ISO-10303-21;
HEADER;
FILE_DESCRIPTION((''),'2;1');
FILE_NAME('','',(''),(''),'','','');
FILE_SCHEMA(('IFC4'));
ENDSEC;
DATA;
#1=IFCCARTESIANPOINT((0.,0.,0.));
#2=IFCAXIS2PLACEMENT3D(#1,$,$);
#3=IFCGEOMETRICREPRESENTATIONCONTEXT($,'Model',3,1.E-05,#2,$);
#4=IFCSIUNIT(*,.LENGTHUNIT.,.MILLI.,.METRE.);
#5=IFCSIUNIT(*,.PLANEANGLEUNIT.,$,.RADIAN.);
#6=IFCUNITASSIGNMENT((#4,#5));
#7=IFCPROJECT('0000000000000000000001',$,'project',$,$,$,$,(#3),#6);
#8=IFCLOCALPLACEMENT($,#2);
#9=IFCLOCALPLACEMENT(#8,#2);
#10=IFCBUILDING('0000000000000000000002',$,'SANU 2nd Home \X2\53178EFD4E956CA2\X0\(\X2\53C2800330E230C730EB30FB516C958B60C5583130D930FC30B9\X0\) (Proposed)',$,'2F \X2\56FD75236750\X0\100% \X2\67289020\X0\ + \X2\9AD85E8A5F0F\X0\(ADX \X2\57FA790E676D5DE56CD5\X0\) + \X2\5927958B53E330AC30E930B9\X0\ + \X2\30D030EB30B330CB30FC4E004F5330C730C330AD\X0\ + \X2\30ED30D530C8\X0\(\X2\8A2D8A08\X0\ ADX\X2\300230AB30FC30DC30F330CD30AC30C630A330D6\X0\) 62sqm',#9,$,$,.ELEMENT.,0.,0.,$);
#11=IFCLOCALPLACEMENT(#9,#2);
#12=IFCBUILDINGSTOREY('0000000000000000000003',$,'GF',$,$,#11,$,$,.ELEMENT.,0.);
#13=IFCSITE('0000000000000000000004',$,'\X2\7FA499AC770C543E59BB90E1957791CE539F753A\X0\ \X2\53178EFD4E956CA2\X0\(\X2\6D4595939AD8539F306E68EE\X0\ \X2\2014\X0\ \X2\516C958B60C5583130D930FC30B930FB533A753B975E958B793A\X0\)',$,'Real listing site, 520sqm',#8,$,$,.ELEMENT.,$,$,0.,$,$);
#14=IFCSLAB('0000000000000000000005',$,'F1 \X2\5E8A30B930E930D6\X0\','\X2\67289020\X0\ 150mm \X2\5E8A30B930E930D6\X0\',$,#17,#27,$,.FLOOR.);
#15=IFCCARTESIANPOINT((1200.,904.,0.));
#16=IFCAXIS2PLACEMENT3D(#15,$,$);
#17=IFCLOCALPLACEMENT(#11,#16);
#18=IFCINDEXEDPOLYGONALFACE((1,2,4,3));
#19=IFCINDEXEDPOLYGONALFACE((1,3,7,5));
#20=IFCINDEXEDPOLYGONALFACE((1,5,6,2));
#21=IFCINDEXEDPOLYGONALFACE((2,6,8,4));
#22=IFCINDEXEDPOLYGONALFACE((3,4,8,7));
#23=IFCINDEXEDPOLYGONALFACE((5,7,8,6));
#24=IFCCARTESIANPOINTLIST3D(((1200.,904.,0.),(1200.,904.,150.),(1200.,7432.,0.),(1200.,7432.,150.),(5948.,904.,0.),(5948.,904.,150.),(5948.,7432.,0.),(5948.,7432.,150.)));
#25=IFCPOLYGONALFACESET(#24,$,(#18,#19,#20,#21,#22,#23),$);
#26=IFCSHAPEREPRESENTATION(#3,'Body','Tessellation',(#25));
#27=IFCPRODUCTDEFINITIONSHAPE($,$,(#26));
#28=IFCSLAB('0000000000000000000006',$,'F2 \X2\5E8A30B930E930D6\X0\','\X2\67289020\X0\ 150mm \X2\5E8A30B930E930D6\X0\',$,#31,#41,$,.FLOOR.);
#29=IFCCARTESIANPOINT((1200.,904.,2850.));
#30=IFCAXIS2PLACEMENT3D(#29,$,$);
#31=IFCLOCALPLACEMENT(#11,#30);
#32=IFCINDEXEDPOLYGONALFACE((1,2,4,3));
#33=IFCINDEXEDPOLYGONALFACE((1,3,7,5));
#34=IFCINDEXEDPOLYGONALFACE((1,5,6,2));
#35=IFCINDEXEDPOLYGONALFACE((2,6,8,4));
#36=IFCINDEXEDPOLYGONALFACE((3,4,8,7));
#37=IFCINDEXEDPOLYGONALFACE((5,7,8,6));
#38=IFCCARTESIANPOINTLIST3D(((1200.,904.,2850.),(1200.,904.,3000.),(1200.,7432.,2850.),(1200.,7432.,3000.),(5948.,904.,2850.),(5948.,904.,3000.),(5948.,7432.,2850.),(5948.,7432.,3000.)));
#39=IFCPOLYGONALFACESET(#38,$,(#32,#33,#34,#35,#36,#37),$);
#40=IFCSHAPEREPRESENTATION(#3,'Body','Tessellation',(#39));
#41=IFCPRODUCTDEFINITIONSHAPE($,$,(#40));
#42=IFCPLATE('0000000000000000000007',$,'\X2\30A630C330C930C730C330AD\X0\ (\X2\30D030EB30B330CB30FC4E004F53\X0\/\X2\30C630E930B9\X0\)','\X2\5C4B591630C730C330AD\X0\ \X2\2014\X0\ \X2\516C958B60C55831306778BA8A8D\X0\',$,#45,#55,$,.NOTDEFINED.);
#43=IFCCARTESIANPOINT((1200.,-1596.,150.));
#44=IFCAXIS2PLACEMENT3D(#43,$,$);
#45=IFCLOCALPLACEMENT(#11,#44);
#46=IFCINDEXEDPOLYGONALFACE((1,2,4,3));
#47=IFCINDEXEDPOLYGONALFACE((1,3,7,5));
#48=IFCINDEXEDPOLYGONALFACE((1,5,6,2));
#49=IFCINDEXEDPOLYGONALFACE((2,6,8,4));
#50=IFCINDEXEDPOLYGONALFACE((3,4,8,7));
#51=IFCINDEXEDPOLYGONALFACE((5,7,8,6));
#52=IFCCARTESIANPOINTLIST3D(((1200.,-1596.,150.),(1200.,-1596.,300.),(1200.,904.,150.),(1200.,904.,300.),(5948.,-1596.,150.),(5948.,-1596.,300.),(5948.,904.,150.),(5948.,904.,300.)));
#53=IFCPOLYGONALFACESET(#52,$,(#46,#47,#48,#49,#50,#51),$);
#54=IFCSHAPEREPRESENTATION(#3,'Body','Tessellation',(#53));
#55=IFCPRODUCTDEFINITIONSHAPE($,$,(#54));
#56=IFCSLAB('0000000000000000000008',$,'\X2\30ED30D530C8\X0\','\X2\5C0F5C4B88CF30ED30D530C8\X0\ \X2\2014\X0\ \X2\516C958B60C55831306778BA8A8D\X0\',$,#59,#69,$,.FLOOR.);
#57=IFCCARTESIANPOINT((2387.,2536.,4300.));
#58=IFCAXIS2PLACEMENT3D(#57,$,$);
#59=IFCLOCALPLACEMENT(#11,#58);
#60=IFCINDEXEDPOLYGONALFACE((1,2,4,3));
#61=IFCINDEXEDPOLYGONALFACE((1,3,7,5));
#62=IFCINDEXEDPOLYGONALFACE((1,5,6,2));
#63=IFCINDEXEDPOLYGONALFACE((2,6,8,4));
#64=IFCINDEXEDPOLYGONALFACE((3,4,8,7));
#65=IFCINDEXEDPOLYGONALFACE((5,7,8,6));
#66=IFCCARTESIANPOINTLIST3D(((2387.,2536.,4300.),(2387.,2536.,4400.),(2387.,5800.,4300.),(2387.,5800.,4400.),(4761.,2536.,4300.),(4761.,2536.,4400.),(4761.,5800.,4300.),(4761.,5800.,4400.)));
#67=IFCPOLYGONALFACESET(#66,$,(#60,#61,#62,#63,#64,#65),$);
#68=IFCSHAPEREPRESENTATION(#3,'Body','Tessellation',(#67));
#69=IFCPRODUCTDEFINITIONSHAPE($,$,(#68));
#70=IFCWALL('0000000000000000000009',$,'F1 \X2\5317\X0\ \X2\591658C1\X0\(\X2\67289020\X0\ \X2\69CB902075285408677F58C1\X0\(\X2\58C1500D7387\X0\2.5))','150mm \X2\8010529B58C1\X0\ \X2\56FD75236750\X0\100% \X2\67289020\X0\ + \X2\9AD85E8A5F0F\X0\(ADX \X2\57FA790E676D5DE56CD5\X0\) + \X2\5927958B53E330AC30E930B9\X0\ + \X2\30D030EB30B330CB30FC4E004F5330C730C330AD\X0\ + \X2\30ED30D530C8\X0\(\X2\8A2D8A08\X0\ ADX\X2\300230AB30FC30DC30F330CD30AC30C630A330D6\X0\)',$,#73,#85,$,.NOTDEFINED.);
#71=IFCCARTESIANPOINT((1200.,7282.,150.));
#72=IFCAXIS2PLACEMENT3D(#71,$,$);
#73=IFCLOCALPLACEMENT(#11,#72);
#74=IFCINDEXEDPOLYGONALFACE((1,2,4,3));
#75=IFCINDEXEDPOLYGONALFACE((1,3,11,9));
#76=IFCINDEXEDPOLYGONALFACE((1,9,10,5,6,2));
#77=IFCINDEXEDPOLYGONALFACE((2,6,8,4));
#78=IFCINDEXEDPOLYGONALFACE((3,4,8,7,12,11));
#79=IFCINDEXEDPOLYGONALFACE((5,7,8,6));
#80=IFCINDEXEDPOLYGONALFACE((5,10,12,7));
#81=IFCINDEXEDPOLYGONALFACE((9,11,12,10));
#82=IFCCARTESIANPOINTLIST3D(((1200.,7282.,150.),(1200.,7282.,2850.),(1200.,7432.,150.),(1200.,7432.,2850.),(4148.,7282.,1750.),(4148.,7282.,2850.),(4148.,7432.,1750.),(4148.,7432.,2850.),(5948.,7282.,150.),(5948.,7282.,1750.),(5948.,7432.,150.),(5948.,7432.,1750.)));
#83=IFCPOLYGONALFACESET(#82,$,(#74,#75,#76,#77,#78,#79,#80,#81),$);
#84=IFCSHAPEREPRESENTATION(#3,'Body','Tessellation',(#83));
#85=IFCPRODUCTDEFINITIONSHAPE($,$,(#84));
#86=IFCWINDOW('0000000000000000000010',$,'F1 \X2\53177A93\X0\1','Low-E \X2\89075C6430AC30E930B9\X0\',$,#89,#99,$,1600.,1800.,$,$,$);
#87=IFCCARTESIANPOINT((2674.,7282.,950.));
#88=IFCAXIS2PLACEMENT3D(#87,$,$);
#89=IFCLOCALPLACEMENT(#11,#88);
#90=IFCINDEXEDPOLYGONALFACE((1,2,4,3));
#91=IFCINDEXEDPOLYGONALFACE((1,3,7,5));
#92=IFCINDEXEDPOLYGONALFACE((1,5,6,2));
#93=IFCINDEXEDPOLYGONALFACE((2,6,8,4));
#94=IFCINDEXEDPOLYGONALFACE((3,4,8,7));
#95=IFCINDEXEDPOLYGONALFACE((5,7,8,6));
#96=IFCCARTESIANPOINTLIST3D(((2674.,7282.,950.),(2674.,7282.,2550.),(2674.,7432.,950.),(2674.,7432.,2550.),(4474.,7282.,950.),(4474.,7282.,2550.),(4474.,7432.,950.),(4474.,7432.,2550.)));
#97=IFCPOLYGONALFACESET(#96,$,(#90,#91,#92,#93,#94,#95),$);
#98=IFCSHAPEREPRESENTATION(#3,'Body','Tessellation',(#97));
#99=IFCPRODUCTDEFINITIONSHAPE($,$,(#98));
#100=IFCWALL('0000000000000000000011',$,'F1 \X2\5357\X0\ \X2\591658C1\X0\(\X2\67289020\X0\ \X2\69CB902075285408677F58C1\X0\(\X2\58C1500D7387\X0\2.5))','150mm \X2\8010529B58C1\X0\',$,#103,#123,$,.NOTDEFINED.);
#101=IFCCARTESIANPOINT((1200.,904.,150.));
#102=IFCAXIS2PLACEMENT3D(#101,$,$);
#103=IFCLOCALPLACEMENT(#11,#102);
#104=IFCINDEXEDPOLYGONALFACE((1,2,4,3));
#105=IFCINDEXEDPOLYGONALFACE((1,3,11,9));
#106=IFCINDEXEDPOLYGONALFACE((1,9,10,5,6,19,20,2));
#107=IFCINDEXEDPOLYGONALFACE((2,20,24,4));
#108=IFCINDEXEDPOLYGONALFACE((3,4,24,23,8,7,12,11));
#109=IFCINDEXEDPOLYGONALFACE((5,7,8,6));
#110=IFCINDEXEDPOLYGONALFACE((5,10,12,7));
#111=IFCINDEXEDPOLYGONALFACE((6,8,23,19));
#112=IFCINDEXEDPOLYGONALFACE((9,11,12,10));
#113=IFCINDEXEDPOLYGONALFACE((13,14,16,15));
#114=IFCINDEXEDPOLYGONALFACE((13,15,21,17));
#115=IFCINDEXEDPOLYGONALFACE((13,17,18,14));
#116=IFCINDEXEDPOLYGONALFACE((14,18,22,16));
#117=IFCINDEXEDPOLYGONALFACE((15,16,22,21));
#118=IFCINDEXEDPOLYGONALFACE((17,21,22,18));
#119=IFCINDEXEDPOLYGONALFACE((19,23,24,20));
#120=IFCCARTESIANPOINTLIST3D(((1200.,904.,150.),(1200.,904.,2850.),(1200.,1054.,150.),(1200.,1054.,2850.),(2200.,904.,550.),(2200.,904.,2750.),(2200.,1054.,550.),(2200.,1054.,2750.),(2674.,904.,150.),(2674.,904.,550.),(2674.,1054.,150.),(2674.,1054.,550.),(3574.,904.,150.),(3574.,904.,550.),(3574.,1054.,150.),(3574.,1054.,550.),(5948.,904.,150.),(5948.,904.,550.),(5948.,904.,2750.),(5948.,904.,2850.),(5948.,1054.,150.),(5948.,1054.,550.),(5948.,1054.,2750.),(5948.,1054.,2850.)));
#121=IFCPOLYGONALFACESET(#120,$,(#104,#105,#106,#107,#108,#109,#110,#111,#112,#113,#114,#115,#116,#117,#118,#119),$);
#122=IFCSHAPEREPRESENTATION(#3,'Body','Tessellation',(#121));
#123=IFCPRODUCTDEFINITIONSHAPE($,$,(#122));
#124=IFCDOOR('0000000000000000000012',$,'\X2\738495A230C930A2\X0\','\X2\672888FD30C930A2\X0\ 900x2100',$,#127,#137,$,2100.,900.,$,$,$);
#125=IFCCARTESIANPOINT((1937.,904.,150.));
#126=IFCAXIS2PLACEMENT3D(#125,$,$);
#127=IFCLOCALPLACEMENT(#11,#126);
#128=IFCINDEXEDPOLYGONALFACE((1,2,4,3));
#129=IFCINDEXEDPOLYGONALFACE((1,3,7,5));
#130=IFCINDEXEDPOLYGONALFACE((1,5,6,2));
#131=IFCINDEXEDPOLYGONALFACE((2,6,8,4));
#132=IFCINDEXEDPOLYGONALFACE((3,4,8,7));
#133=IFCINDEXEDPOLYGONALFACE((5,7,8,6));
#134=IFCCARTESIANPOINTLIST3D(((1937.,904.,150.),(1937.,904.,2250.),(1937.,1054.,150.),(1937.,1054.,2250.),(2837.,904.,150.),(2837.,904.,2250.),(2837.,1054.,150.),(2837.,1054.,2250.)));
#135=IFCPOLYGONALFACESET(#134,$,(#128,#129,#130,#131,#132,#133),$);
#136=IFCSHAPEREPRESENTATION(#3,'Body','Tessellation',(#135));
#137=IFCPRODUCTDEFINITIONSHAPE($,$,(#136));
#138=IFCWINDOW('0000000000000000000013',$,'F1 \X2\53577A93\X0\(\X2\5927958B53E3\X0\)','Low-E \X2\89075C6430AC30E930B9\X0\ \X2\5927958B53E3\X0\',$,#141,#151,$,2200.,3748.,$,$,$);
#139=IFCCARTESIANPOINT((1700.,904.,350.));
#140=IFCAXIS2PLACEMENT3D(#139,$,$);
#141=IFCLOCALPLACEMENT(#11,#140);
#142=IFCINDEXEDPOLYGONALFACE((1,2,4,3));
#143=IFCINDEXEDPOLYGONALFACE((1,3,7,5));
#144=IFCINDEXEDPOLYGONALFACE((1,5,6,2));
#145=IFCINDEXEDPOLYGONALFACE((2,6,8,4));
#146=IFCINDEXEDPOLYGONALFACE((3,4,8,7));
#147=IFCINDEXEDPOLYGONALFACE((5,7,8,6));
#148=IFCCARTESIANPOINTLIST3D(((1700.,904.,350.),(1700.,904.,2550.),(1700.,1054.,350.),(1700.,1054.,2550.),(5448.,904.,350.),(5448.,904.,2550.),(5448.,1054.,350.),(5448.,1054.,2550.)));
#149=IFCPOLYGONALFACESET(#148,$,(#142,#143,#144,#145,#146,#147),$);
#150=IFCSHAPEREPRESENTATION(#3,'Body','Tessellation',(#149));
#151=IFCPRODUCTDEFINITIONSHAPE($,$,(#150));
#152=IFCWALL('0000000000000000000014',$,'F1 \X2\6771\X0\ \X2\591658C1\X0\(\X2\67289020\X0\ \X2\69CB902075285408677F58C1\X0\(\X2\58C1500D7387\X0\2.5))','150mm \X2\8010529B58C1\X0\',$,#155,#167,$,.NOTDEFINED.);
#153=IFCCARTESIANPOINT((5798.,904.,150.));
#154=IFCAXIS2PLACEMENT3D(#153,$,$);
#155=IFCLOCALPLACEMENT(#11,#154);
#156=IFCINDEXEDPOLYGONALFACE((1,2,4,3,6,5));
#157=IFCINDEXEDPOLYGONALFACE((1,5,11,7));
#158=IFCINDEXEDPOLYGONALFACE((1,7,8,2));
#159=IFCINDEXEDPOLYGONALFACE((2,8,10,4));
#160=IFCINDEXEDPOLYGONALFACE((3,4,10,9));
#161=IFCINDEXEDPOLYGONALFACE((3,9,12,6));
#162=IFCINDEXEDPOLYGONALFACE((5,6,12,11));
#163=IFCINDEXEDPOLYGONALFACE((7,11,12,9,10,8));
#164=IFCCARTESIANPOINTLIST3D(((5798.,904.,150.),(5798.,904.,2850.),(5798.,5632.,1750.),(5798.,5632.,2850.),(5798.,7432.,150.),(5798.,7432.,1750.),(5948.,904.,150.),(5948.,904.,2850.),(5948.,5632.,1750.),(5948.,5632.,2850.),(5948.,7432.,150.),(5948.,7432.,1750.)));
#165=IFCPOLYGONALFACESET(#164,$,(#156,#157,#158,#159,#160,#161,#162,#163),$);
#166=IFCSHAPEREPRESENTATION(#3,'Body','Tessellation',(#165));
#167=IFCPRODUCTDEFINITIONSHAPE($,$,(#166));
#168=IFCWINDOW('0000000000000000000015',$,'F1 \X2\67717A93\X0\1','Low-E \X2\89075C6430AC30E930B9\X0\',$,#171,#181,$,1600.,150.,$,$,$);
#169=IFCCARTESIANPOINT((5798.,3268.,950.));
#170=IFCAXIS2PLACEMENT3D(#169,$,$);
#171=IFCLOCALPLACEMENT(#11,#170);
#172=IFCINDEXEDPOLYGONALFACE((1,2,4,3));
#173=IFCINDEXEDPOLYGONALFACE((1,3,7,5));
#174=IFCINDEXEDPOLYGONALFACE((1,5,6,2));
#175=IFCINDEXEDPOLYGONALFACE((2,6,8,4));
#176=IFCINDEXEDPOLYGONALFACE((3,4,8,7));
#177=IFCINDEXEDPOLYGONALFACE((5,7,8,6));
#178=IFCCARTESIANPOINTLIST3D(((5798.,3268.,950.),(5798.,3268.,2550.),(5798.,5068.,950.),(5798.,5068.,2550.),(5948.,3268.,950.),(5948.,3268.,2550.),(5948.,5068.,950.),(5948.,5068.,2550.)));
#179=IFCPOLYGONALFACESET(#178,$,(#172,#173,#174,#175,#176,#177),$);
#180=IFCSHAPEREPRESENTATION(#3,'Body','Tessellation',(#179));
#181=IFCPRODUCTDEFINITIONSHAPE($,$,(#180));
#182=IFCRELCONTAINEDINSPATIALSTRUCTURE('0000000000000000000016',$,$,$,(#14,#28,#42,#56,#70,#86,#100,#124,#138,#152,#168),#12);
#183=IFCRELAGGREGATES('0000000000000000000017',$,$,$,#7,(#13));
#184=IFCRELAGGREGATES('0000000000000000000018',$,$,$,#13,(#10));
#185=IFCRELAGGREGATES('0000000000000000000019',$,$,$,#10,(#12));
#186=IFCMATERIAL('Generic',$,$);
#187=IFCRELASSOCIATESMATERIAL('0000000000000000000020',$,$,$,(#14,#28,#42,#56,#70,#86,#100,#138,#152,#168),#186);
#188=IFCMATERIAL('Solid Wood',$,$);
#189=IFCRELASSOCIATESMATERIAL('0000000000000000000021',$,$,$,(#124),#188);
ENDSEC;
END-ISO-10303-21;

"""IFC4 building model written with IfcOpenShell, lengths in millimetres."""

from ifc_helpers import new_model, si_unit, frame, frame_2d, origin, place, context, project, spatial, rectangle, extrude, material, element, fill, save


model = new_model("IFC4")

# Units and contexts
model_context = context("Model", 3, precision=1e-05, world=origin())
ifc_project = project(units=[si_unit("LENGTHUNIT", "METRE", prefix="MILLI"), si_unit("PLANEANGLEUNIT", "RADIAN")], contexts=[model_context])

# Site, building, storey
site_placement = place(None, origin())
site = spatial("IfcSite", under=ifc_project, at=site_placement, Name="群馬県吾妻郡長野原町 北軽井沢(浅間高原の森 — 公開情報ベース・区画非開示)", ObjectType="Real listing site, 520sqm", CompositionType="ELEMENT", RefElevation=0.0)
building_placement = place(site_placement, origin())
building = spatial("IfcBuilding", under=site, at=building_placement, Name="SANU 2nd Home 北軽井沢(参考モデル・公開情報ベース) (Proposed)", ObjectType="2F 国産材100% 木造 + 高床式(ADX 基礎杭工法) + 大開口ガラス + バルコニー一体デッキ + ロフト(設計 ADX。カーボンネガティブ) 62sqm", CompositionType="ELEMENT", ElevationOfRefHeight=0.0, ElevationOfTerrain=0.0)
storey_placement = place(building_placement, origin())
storey = spatial("IfcBuildingStorey", under=building, at=storey_placement, Name="GF", CompositionType="ELEMENT", Elevation=0.0)

# Slabs
ifc_material_1 = material(Name="Generic")
slab_1_placement = place(storey_placement, frame((1200.0, 904.0, 0.0)))
element("IfcSlab", 1, at=slab_1_placement, inside=storey, material=ifc_material_1, Name="F1 床スラブ", Description="木造 150mm 床スラブ", PredefinedType="FLOOR", context=model_context, shape_type="SweptSolid", body=[
    extrude(rectangle(XDim=4748.0, YDim=6528.0, at=frame_2d((2374.0, 3264.0))), frame((1200.0, 904.0, 0.0)), (0.0, 0.0, 1.0), 150.0),
])
slab_2_placement = place(storey_placement, frame((1200.0, 904.0, 2850.0)))
element("IfcSlab", 2, at=slab_2_placement, inside=storey, material=ifc_material_1, Name="F2 床スラブ", Description="木造 150mm 床スラブ", PredefinedType="FLOOR", context=model_context, shape_type="SweptSolid", body=[
    extrude(rectangle(XDim=4748.0, YDim=6528.0, at=frame_2d((2374.0, 3264.0))), frame((1200.0, 904.0, 2850.0)), (0.0, 0.0, 1.0), 150.0),
])

# Plate
plate_placement = place(storey_placement, frame((1200.0, -1596.0, 150.0)))
element("IfcPlate", 3, at=plate_placement, inside=storey, material=ifc_material_1, Name="ウッドデッキ (バルコニー一体/テラス)", Description="屋外デッキ — 公開情報で確認", PredefinedType="NOTDEFINED", context=model_context, shape_type="SweptSolid", body=[
    extrude(rectangle(XDim=4748.0, YDim=2500.0, at=frame_2d((2374.0, 1250.0))), frame((1200.0, -1596.0, 150.0)), (0.0, 0.0, 1.0), 150.0),
])

# Slab
slab_3_placement = place(storey_placement, frame((2387.0, 2536.0, 4300.0)))
element("IfcSlab", 4, at=slab_3_placement, inside=storey, material=ifc_material_1, Name="ロフト", Description="小屋裏ロフト — 公開情報で確認", PredefinedType="FLOOR", context=model_context, shape_type="SweptSolid", body=[
    extrude(rectangle(XDim=2374.0, YDim=3264.0, at=frame_2d((1187.0, 1632.0))), frame((2387.0, 2536.0, 4300.0)), (0.0, 0.0, 1.0), 100.0),
])

# Wall, opening, window
wall_1_placement = place(storey_placement, frame((1200.0, 7282.0, 150.0)))
wall_1 = element("IfcWall", 5, at=wall_1_placement, inside=storey, material=ifc_material_1, Name="F1 北 外壁(木造 構造用合板壁(壁倍率2.5))", Description="150mm 耐力壁 国産材100% 木造 + 高床式(ADX 基礎杭工法) + 大開口ガラス + バルコニー一体デッキ + ロフト(設計 ADX。カーボンネガティブ)", PredefinedType="NOTDEFINED", context=model_context, shape_type="SweptSolid", body=[
    extrude(rectangle(XDim=4748.0, YDim=150.0, at=frame_2d((2374.0, 75.0))), frame((1200.0, 7282.0, 150.0)), (0.0, 0.0, 1.0), 2700.0),
])
opening_1_placement = place(storey_placement, frame((2674.0, 7282.0, 950.0)))
opening_1 = element("IfcOpeningElement", 6, at=opening_1_placement, cuts=wall_1, PredefinedType="NOTDEFINED", context=model_context, shape_type="SweptSolid", body=[
    extrude(rectangle(XDim=1800.0, YDim=150.0, at=frame_2d((900.0, 75.0))), frame((2674.0, 7282.0, 950.0)), (0.0, 0.0, 1.0), 1600.0),
])
window_1_placement = place(storey_placement, frame((2674.0, 7282.0, 950.0)))
window_1 = element("IfcWindow", 7, at=window_1_placement, inside=storey, material=ifc_material_1, Name="F1 北窓1", Description="Low-E 複層ガラス", OverallHeight=1600.0, OverallWidth=1800.0, context=model_context, shape_type="SweptSolid", body=[
    extrude(rectangle(XDim=1800.0, YDim=150.0, at=frame_2d((900.0, 75.0))), frame((2674.0, 7282.0, 950.0)), (0.0, 0.0, 1.0), 1600.0),
])
fill(opening_1, window_1)

# Wall, openings, door, window
wall_2_placement = place(storey_placement, frame((1200.0, 904.0, 150.0)))
wall_2 = element("IfcWall", 8, at=wall_2_placement, inside=storey, material=ifc_material_1, Name="F1 南 外壁(木造 構造用合板壁(壁倍率2.5))", Description="150mm 耐力壁", PredefinedType="NOTDEFINED", context=model_context, shape_type="SweptSolid", body=[
    extrude(rectangle(XDim=4748.0, YDim=150.0, at=frame_2d((2374.0, 75.0))), frame((1200.0, 904.0, 150.0)), (0.0, 0.0, 1.0), 2700.0),
])
opening_2_placement = place(storey_placement, frame((1937.0, 904.0, 150.0)))
opening_2 = element("IfcOpeningElement", 9, at=opening_2_placement, cuts=wall_2, PredefinedType="NOTDEFINED", context=model_context, shape_type="SweptSolid", body=[
    extrude(rectangle(XDim=900.0, YDim=150.0, at=frame_2d((450.0, 75.0))), frame((1937.0, 904.0, 150.0)), (0.0, 0.0, 1.0), 2100.0),
])
opening_3_placement = place(storey_placement, frame((1700.0, 904.0, 350.0)))
opening_3 = element("IfcOpeningElement", 10, at=opening_3_placement, cuts=wall_2, PredefinedType="NOTDEFINED", context=model_context, shape_type="SweptSolid", body=[
    extrude(rectangle(XDim=3748.0, YDim=150.0, at=frame_2d((1874.0, 75.0))), frame((1700.0, 904.0, 350.0)), (0.0, 0.0, 1.0), 2200.0),
])
ifc_material_2 = material(Name="Solid Wood")
door_placement = place(storey_placement, frame((1937.0, 904.0, 150.0)))
door = element("IfcDoor", 11, at=door_placement, inside=storey, material=ifc_material_2, Name="玄関ドア", Description="木製ドア 900x2100", OverallHeight=2100.0, OverallWidth=900.0, context=model_context, shape_type="SweptSolid", body=[
    extrude(rectangle(XDim=900.0, YDim=150.0, at=frame_2d((450.0, 75.0))), frame((1937.0, 904.0, 150.0)), (0.0, 0.0, 1.0), 2100.0),
])
fill(opening_2, door)
window_2_placement = place(storey_placement, frame((1700.0, 904.0, 350.0)))
window_2 = element("IfcWindow", 12, at=window_2_placement, inside=storey, material=ifc_material_1, Name="F1 南窓(大開口)", Description="Low-E 複層ガラス 大開口", OverallHeight=2200.0, OverallWidth=3748.0, context=model_context, shape_type="SweptSolid", body=[
    extrude(rectangle(XDim=3748.0, YDim=150.0, at=frame_2d((1874.0, 75.0))), frame((1700.0, 904.0, 350.0)), (0.0, 0.0, 1.0), 2200.0),
])
fill(opening_3, window_2)

# Wall, opening, window
wall_3_placement = place(storey_placement, frame((5798.0, 904.0, 150.0)))
wall_3 = element("IfcWall", 13, at=wall_3_placement, inside=storey, material=ifc_material_1, Name="F1 東 外壁(木造 構造用合板壁(壁倍率2.5))", Description="150mm 耐力壁", PredefinedType="NOTDEFINED", context=model_context, shape_type="SweptSolid", body=[
    extrude(rectangle(XDim=150.0, YDim=6528.0, at=frame_2d((75.0, 3264.0))), frame((5798.0, 904.0, 150.0)), (0.0, 0.0, 1.0), 2700.0),
])
opening_4_placement = place(storey_placement, frame((5798.0, 3268.0, 950.0)))
opening_4 = element("IfcOpeningElement", 14, at=opening_4_placement, cuts=wall_3, PredefinedType="NOTDEFINED", context=model_context, shape_type="SweptSolid", body=[
    extrude(rectangle(XDim=150.0, YDim=1800.0, at=frame_2d((75.0, 900.0))), frame((5798.0, 3268.0, 950.0)), (0.0, 0.0, 1.0), 1600.0),
])
window_3_placement = place(storey_placement, frame((5798.0, 3268.0, 950.0)))
window_3 = element("IfcWindow", 15, at=window_3_placement, inside=storey, material=ifc_material_1, Name="F1 東窓1", Description="Low-E 複層ガラス", OverallHeight=1600.0, OverallWidth=150.0, context=model_context, shape_type="SweptSolid", body=[
    extrude(rectangle(XDim=150.0, YDim=1800.0, at=frame_2d((75.0, 900.0))), frame((5798.0, 3268.0, 950.0)), (0.0, 0.0, 1.0), 1600.0),
])
fill(opening_4, window_3)

save(model, "model.ifc")
